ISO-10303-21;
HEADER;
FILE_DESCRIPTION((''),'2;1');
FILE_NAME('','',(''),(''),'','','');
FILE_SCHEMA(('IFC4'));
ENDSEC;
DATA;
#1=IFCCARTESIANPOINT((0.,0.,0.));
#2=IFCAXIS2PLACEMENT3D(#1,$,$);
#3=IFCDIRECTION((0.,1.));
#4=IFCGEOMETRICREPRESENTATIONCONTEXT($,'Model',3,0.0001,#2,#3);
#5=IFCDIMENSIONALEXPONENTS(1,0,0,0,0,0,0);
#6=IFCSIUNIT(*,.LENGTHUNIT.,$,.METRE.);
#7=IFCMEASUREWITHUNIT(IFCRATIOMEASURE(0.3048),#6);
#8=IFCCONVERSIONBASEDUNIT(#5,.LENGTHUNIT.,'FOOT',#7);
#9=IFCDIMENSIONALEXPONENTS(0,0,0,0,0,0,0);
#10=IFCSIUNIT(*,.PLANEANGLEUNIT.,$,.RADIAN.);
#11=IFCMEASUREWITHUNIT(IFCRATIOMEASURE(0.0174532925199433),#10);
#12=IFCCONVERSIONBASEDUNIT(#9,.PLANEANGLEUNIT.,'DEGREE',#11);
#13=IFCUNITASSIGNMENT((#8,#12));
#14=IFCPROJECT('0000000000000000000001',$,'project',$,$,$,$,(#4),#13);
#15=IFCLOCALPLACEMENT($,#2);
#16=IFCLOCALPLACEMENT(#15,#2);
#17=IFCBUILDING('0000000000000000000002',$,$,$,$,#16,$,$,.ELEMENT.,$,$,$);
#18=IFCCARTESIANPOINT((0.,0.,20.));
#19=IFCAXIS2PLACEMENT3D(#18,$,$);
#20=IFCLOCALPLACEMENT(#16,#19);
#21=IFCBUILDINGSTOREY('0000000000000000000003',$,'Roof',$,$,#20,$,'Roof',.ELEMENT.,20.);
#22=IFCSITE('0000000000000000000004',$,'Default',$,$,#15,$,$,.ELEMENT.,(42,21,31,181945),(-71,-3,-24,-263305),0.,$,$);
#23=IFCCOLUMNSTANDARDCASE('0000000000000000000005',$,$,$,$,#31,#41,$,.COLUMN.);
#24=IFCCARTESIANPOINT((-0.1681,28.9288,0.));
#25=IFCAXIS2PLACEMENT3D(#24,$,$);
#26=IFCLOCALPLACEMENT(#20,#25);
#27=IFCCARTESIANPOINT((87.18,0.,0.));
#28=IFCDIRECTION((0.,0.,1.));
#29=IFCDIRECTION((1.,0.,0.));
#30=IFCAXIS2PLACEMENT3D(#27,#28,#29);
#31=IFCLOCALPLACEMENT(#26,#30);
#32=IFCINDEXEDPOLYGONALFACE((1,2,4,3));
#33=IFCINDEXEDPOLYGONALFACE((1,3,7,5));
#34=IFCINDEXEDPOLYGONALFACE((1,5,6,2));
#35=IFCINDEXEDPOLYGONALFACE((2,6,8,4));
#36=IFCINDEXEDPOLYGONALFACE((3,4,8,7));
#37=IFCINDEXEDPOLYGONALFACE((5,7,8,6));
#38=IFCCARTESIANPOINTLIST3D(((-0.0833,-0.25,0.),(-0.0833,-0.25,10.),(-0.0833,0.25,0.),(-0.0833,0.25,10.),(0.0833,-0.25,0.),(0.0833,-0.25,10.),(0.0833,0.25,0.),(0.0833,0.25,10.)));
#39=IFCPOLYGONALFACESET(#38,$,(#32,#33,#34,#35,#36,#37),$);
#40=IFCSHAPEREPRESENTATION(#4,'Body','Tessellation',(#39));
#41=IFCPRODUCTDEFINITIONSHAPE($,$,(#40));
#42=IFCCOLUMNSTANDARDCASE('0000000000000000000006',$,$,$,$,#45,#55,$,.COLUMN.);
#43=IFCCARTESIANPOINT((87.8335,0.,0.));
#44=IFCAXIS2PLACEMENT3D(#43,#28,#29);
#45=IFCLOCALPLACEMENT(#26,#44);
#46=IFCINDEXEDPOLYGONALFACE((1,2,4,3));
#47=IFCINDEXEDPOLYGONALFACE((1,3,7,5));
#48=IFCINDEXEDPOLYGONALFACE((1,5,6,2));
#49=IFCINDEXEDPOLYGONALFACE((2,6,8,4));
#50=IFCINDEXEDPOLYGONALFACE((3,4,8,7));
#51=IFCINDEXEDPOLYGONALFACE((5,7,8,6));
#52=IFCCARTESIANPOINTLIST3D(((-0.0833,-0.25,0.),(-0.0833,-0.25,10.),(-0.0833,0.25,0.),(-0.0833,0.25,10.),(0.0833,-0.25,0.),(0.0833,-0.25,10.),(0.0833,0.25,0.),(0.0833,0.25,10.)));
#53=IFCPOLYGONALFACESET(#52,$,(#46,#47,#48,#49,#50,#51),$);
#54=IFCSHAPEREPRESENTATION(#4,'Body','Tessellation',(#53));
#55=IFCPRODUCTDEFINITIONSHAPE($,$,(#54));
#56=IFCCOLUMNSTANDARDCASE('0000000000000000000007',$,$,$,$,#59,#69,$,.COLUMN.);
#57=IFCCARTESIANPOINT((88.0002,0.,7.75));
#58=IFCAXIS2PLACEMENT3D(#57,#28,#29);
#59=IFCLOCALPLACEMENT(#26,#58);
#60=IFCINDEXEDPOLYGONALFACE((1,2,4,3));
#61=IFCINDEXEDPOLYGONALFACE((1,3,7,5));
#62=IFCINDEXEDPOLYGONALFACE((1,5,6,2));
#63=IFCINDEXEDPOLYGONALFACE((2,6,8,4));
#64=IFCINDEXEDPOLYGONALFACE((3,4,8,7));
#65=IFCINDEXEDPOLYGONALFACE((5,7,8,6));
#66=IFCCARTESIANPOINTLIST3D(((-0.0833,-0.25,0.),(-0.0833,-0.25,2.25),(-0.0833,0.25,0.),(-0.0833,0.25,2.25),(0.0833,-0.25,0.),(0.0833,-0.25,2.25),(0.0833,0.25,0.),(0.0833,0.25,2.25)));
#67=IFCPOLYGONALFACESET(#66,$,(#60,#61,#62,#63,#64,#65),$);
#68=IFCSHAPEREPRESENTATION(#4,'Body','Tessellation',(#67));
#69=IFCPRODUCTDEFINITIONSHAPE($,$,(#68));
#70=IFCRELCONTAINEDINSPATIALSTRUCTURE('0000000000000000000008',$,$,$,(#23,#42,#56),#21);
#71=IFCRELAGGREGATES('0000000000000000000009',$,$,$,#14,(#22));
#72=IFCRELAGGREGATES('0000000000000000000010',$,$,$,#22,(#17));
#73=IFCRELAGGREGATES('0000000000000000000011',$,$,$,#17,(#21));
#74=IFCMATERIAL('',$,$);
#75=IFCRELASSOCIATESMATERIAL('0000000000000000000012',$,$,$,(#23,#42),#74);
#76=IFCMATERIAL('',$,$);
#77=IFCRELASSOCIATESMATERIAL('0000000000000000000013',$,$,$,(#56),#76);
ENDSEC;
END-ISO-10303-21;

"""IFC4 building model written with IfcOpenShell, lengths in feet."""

from ifc_helpers import new_model, entity, si_unit, converted_unit, direction, frame, origin, place, context, project, spatial, rectangle, extrude, material, element, save


model = new_model("IFC4")

# Units and contexts
model_context = context("Model", 3, precision=0.0001, world=origin(), true_north=direction((0.0, 1.0)))
ifc_project = project(units=[converted_unit("LENGTHUNIT", "FOOT", entity("IfcRatioMeasure", 0.3048), si_unit("LENGTHUNIT", "METRE"), dimensions=[1, 0, 0, 0, 0, 0, 0]), converted_unit("PLANEANGLEUNIT", "DEGREE", entity("IfcRatioMeasure", 0.0174532925199433), si_unit("PLANEANGLEUNIT", "RADIAN"), dimensions=[0, 0, 0, 0, 0, 0, 0])], contexts=[model_context])

# Site, building, storey
site_placement = place(None, origin())
site = spatial("IfcSite", under=ifc_project, at=site_placement, Name="Default", CompositionType="ELEMENT", RefLatitude=(42, 21, 31, 181945), RefLongitude=(-71, -3, -24, -263305), RefElevation=0.0)
building_placement = place(site_placement, origin())
building = spatial("IfcBuilding", under=site, at=building_placement, CompositionType="ELEMENT")
storey_placement = place(building_placement, frame((0.0, 0.0, 20.0)))
storey = spatial("IfcBuildingStorey", under=building, at=storey_placement, Name="Roof", LongName="Roof", CompositionType="ELEMENT", Elevation=20.0)

# Columns
ifc_material_1 = material(Name="")
placement_1 = place(storey_placement, frame((-0.1681, 28.9288, 0.0)))
for number, where, z_axis, x_axis in (
    (1, (87.18, 0.0, 0.0), (0.0, 0.0, 1.0), (1.0, 0.0, 0.0)),
    (2, (87.8335, 0.0, 0.0), (0.0, 0.0, 1.0), (1.0, 0.0, 0.0)),
):
    element("IfcColumnStandardCase", number, at=place(placement_1, frame(where, z_axis=z_axis, x_axis=x_axis)), inside=storey, material=ifc_material_1, PredefinedType="COLUMN", context=model_context, shape_type="SweptSolid", body=[
        extrude(rectangle(XDim=0.1667, YDim=0.5), origin(), (0.0, 0.0, 1.0), 10.0),
    ])
ifc_material_2 = material(Name="")
for number, where, z_axis, x_axis in (
    (3, (88.0002, 0.0, 7.75), (0.0, 0.0, 1.0), (1.0, 0.0, 0.0)),
):
    element("IfcColumnStandardCase", number, at=place(placement_1, frame(where, z_axis=z_axis, x_axis=x_axis)), inside=storey, material=ifc_material_2, PredefinedType="COLUMN", context=model_context, shape_type="SweptSolid", body=[
        extrude(rectangle(XDim=0.1667, YDim=0.5), origin(), (0.0, 0.0, 1.0), 2.25),
    ])

save(model, "model.ifc")
